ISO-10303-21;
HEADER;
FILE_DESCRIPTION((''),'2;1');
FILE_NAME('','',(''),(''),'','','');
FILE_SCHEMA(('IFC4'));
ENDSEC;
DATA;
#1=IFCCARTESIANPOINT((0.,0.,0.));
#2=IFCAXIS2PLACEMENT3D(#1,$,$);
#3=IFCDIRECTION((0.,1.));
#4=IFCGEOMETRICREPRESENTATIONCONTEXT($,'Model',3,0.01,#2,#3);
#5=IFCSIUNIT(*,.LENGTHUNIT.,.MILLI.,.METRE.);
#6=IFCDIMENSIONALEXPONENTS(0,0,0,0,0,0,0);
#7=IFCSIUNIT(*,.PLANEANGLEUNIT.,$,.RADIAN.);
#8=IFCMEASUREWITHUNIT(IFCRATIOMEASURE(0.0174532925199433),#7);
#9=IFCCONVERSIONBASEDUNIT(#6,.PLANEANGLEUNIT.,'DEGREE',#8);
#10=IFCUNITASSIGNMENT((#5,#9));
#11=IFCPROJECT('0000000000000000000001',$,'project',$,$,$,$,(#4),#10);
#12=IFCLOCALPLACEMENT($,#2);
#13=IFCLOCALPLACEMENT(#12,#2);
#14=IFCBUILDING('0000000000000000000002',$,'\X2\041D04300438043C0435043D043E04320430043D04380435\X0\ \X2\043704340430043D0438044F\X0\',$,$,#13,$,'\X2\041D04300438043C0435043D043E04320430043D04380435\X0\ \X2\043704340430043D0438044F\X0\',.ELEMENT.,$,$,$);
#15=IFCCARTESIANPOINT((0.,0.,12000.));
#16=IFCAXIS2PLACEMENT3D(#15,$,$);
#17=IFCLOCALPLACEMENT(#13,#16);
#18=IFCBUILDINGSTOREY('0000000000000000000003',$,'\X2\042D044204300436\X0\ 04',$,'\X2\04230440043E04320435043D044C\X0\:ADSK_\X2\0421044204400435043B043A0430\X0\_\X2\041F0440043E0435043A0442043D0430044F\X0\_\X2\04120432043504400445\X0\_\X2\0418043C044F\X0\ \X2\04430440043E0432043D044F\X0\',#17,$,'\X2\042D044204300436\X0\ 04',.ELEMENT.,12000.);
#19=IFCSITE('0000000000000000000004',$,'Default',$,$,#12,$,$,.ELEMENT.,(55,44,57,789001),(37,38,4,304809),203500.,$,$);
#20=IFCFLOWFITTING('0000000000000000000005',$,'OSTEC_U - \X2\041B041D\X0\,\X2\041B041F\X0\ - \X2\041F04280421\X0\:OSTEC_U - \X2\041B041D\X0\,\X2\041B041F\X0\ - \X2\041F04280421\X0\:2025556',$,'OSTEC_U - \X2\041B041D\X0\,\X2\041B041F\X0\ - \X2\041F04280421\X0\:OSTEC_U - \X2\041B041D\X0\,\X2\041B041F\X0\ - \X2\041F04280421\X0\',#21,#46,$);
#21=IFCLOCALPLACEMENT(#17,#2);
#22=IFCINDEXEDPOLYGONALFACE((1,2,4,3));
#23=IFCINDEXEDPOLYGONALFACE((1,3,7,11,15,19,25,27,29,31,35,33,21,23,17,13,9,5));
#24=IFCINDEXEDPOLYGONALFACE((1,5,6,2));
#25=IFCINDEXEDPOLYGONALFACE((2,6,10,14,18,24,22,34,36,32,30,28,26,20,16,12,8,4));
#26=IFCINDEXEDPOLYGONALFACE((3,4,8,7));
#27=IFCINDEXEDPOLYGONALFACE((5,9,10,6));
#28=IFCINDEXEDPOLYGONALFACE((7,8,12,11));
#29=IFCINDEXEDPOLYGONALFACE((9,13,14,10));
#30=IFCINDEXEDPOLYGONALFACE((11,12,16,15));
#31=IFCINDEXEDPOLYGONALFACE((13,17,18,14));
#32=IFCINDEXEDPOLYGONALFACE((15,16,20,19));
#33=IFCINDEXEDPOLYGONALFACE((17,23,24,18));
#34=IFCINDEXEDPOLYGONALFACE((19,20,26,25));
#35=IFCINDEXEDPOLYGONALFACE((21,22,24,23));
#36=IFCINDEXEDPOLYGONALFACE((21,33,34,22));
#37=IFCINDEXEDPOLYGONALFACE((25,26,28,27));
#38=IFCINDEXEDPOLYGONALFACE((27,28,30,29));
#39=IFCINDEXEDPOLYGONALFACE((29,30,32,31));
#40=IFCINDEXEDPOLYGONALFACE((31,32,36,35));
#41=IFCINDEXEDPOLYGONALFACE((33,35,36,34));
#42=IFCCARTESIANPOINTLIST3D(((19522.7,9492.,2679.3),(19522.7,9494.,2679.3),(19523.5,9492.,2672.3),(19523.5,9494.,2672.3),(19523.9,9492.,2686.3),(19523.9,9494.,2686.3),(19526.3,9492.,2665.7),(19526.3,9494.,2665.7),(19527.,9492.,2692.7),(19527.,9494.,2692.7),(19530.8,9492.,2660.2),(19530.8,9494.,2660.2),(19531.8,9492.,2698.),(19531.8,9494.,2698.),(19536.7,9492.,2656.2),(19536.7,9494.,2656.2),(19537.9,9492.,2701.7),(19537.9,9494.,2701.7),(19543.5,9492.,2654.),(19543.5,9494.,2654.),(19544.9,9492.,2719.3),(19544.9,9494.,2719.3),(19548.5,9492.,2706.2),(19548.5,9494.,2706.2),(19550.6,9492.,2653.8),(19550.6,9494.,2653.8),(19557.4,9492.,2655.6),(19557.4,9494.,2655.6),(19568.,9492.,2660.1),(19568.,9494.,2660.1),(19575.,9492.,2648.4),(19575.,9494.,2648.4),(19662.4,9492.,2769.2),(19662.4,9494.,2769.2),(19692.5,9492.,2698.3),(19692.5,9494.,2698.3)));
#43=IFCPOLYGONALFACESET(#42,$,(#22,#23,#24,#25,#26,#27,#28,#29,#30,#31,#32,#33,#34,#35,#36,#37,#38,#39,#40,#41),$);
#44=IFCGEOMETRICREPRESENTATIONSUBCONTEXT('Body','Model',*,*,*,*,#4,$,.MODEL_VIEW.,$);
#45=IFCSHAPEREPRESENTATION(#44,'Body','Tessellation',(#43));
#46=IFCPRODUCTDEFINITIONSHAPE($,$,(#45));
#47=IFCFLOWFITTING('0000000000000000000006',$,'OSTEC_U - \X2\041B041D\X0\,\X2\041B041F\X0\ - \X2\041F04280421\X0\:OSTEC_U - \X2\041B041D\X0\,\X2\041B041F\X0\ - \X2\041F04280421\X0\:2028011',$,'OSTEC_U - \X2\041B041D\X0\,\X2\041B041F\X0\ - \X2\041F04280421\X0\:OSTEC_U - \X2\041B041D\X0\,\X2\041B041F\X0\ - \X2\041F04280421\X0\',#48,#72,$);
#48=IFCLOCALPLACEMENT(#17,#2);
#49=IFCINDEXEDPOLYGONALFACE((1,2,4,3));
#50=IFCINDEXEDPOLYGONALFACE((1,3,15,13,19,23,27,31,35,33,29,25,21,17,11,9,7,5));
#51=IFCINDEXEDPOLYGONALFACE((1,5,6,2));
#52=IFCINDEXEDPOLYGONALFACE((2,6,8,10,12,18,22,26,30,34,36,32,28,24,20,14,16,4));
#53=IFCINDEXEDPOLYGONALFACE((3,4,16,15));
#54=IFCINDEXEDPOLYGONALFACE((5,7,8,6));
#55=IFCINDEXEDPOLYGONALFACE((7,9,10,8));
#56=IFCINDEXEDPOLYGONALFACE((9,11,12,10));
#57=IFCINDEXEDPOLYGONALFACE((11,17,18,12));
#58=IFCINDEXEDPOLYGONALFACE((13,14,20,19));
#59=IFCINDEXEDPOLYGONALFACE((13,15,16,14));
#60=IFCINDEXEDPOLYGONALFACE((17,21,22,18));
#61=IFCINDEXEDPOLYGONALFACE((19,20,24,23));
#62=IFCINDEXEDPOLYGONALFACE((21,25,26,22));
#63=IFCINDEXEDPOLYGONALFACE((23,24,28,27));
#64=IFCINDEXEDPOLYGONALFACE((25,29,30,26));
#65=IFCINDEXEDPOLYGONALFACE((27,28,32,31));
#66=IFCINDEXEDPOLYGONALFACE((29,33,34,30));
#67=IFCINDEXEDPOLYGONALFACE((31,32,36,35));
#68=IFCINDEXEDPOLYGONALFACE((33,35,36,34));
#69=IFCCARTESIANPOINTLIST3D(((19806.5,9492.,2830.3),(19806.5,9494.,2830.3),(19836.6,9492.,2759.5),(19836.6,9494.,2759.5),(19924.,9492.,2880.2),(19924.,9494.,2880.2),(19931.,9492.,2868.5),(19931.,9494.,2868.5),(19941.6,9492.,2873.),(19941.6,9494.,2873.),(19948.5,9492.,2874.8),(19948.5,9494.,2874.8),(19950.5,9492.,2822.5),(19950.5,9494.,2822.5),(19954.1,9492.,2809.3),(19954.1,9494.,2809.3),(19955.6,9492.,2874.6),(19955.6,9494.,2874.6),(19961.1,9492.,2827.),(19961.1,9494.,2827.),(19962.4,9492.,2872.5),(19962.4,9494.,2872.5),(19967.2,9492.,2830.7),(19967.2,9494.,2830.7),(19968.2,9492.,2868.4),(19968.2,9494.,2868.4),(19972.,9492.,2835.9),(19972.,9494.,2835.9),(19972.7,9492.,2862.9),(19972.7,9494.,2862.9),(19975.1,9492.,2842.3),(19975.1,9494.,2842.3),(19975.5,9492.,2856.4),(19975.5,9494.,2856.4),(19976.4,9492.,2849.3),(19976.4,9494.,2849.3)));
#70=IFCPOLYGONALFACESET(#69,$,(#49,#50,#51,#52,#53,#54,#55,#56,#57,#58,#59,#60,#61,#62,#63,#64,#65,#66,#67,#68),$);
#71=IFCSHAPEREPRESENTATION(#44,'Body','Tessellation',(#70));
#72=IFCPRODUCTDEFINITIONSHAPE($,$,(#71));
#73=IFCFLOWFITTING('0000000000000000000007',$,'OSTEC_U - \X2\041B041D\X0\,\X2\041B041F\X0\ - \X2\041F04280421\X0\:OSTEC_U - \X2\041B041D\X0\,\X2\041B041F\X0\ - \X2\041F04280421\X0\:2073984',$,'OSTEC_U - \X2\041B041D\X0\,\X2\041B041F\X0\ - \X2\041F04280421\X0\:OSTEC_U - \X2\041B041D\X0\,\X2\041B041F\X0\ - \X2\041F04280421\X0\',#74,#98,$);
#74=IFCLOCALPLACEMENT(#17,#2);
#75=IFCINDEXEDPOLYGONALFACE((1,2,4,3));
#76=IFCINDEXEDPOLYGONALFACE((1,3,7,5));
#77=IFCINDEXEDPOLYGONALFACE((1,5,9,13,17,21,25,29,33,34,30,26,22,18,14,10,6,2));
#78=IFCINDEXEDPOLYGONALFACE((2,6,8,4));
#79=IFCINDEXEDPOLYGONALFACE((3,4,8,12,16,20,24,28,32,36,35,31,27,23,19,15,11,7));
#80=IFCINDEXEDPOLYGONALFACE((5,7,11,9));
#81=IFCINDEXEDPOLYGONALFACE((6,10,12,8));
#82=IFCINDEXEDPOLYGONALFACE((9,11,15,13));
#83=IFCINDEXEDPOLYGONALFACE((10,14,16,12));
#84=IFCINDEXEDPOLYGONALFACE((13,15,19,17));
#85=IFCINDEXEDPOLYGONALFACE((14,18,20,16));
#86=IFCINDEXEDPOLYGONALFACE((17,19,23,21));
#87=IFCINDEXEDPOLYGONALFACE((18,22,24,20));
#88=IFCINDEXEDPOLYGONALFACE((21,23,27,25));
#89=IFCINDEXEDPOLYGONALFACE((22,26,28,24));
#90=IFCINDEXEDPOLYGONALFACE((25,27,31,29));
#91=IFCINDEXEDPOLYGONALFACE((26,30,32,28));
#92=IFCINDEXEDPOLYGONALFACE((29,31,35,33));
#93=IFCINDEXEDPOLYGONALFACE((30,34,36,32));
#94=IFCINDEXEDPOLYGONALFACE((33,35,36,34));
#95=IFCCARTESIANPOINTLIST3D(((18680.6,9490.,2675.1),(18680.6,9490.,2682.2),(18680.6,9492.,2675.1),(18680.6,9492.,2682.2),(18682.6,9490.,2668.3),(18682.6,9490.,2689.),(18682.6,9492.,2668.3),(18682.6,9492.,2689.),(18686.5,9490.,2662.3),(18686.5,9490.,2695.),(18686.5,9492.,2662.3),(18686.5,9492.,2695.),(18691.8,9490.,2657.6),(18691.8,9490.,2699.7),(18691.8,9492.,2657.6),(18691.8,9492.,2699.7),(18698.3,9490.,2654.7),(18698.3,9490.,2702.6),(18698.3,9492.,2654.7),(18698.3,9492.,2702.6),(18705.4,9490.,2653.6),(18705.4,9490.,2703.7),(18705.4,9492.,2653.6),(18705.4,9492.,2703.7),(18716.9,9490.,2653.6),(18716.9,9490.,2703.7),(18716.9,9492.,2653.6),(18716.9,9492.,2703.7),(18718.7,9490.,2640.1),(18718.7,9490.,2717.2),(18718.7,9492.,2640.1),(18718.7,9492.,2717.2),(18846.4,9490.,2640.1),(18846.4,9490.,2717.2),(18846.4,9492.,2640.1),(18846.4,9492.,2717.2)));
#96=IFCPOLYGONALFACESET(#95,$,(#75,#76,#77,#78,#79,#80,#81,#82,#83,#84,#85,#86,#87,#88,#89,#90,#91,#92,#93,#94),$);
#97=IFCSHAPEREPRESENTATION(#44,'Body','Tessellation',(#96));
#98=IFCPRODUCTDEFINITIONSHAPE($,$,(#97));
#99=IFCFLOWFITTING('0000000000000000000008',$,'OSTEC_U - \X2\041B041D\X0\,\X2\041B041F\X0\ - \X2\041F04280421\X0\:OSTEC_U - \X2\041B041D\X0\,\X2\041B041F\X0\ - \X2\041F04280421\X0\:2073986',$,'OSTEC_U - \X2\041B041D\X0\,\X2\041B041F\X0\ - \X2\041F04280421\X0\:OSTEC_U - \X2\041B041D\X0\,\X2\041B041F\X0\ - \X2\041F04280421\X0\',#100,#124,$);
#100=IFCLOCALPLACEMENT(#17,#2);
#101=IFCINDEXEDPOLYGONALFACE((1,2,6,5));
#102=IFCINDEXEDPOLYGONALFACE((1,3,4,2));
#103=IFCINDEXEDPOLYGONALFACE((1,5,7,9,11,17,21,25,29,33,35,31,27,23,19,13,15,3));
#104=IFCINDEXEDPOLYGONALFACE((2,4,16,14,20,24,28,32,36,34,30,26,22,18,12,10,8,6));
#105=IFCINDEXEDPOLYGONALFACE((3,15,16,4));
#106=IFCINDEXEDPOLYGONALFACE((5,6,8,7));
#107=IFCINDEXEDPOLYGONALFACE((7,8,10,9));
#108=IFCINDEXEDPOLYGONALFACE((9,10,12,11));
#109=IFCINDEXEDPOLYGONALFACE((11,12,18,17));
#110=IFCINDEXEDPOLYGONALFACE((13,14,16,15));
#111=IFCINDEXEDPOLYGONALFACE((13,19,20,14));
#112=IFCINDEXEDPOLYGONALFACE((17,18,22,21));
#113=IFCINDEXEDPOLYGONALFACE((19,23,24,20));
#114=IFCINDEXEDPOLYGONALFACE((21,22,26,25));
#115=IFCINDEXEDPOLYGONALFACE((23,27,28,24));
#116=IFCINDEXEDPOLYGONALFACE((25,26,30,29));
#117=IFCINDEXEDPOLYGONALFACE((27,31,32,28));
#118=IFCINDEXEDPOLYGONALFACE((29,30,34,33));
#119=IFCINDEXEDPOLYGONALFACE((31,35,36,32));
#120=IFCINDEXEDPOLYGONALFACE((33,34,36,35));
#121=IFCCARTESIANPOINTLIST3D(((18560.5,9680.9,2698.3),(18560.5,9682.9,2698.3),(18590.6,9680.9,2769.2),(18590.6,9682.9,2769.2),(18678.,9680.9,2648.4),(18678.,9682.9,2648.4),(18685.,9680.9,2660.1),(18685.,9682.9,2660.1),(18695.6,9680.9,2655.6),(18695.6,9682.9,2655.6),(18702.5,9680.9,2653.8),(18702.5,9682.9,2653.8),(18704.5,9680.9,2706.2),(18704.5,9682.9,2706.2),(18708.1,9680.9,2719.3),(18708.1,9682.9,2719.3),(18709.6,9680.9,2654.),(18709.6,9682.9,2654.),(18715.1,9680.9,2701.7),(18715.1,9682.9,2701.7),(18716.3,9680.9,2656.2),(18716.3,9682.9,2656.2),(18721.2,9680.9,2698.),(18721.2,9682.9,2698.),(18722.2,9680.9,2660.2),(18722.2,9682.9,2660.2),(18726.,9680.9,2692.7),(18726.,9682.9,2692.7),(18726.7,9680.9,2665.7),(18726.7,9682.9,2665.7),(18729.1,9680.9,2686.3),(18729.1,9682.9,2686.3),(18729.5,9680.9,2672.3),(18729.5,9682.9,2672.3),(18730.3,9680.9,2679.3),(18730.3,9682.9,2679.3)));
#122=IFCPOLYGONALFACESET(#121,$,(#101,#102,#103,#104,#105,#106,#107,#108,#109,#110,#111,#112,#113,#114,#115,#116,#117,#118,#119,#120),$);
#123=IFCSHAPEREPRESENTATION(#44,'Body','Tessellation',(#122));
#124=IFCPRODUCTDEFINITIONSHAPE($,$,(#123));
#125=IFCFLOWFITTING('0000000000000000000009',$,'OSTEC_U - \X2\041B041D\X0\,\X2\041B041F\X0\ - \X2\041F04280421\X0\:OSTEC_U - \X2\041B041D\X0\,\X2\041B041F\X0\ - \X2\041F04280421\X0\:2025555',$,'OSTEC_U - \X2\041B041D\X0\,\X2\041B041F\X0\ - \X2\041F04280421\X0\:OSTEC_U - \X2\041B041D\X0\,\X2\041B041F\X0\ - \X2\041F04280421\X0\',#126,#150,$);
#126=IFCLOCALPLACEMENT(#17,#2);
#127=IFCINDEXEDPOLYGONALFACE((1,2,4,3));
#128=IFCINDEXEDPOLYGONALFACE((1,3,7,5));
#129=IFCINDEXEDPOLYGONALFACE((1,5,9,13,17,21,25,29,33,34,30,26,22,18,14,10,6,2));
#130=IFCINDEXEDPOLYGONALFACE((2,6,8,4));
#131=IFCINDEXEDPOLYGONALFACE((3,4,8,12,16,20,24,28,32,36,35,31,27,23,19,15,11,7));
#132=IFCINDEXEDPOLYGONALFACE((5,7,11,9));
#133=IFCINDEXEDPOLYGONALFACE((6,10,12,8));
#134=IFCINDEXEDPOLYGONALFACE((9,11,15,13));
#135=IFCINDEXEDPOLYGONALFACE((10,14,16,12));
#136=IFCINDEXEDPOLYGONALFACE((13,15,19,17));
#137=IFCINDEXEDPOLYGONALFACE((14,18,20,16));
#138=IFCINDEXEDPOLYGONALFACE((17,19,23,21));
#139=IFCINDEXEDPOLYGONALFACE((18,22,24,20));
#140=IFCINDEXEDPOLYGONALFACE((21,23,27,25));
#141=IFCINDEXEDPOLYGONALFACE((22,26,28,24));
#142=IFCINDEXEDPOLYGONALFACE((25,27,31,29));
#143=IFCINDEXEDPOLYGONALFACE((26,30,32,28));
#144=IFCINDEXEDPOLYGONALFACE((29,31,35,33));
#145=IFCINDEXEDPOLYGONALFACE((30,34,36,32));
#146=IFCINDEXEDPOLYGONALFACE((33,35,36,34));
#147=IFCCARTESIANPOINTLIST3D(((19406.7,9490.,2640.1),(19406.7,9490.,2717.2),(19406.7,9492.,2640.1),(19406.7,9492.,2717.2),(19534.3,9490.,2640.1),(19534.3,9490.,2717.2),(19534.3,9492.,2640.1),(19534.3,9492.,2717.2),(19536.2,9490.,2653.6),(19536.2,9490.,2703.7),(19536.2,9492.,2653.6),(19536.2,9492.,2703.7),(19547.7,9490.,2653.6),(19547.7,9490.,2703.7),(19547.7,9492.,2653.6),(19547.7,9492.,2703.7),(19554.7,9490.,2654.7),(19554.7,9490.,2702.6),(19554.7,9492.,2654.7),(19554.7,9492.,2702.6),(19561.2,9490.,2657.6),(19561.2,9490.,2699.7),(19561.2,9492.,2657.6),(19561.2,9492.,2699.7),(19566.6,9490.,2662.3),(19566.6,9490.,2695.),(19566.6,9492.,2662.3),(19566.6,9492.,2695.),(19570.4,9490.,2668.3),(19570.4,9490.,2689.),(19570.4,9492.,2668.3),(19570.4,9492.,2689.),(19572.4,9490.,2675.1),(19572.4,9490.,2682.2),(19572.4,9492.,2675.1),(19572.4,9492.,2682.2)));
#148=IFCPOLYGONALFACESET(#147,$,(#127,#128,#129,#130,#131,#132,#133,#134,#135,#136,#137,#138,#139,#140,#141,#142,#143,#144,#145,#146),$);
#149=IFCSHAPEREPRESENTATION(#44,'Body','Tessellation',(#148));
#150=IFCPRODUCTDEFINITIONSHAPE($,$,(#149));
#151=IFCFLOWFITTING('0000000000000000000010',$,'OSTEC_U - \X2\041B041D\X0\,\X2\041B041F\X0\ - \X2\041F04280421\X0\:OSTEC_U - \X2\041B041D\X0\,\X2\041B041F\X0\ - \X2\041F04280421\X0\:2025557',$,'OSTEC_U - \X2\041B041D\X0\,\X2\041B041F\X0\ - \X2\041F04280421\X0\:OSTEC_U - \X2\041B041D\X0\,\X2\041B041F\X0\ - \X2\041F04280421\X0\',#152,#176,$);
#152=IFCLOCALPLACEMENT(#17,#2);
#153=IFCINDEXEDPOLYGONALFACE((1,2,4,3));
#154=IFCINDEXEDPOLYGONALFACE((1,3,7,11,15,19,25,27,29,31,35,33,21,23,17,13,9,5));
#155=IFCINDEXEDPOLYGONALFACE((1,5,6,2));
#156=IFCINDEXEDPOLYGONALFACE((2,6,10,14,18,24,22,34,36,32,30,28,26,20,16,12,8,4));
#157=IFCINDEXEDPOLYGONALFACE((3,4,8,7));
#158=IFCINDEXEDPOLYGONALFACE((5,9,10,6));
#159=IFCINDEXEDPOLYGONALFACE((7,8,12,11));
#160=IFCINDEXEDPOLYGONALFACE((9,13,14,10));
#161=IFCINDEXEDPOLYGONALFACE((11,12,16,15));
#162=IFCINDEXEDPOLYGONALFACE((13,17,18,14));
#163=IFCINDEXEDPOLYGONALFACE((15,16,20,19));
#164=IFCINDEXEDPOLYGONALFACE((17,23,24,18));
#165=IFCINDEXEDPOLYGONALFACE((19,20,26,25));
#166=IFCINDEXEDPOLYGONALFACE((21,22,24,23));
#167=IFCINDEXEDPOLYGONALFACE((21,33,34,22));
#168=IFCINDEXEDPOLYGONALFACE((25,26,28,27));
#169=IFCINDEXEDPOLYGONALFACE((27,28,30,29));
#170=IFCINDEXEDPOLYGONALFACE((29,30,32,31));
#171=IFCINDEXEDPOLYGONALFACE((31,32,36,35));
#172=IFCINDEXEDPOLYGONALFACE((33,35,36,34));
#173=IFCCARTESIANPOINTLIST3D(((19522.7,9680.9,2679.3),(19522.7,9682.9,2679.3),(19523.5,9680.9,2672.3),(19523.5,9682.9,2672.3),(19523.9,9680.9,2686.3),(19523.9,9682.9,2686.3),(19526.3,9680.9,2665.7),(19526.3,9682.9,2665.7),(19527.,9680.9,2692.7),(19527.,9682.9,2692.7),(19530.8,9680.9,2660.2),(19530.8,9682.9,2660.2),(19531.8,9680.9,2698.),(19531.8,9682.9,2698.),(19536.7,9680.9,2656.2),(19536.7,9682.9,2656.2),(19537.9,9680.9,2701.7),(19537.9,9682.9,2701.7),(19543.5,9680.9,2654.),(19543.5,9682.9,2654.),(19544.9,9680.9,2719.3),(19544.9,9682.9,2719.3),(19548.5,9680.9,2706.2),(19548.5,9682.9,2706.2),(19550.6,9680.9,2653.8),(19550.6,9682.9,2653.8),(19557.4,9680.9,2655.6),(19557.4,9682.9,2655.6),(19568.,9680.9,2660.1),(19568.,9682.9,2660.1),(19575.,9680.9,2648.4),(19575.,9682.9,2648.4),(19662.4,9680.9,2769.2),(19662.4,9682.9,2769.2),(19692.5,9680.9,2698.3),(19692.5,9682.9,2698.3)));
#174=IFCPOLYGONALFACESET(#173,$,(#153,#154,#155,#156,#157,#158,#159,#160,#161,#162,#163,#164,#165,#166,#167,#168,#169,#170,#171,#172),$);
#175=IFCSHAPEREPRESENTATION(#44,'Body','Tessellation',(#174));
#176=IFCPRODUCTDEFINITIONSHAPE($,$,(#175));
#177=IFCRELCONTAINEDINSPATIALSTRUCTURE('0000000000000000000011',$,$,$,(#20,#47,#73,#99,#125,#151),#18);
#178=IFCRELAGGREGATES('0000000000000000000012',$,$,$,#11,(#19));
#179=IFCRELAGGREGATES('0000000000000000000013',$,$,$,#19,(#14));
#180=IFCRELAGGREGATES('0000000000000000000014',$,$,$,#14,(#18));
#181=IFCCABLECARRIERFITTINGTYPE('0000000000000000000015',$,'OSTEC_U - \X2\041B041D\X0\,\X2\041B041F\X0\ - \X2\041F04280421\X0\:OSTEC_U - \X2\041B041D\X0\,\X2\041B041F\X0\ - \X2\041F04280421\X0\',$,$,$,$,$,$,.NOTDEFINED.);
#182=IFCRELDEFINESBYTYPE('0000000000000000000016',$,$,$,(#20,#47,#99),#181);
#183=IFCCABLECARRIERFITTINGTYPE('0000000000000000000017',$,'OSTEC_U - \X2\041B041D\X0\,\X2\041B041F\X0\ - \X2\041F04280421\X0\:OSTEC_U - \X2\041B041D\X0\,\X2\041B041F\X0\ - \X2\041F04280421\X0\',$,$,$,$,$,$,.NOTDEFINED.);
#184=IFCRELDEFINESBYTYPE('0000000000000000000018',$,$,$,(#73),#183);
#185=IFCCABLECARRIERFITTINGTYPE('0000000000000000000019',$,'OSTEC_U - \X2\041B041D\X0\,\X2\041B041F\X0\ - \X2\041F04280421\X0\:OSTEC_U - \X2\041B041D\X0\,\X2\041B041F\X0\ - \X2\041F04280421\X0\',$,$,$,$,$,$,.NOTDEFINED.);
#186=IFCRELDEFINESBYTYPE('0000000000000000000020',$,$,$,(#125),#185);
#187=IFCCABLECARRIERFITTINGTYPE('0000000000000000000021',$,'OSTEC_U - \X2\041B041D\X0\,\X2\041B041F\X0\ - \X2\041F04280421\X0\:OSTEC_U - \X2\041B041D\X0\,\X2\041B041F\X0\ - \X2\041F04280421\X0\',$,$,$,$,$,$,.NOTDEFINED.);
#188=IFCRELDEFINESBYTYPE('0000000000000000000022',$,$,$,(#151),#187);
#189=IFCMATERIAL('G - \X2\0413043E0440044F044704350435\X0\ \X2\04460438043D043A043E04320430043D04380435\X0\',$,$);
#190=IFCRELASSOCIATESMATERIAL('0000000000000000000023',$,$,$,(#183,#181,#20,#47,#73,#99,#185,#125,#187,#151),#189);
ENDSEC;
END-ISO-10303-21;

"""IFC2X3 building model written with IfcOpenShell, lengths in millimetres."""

from ifc_helpers import new_model, entity, si_unit, converted_unit, direction, frame, frame_2d, origin, place, context, subcontext, project, spatial, polyline, circle_curve, parameter, trimmed, segment, composite_curve, outline, extrude, source, transform, mapped, material, type_object, type_shapes, element, save


model = new_model("IFC2X3")

# Units and contexts
model_context = context("Model", 3, precision=0.01, world=origin(), true_north=direction((0.0, 1.0)))
body_context = subcontext(model_context, "Body", "Model", "MODEL_VIEW")
ifc_project = project(units=[si_unit("LENGTHUNIT", "METRE", prefix="MILLI"), converted_unit("PLANEANGLEUNIT", "DEGREE", entity("IfcRatioMeasure", 0.0174532925199433), si_unit("PLANEANGLEUNIT", "RADIAN"), dimensions=[0, 0, 0, 0, 0, 0, 0])], contexts=[model_context])

# Site, building, storey
site_placement = place(None, origin())
site = spatial("IfcSite", under=ifc_project, at=site_placement, Name="Default", CompositionType="ELEMENT", RefLatitude=(55, 44, 57, 789001), RefLongitude=(37, 38, 4, 304809), RefElevation=203500.0)
building_placement = place(site_placement, origin())
building = spatial("IfcBuilding", under=site, at=building_placement, Name="Наименование здания", LongName="Наименование здания", CompositionType="ELEMENT")
storey_placement = place(building_placement, frame((0.0, 0.0, 12000.0)))
storey = spatial("IfcBuildingStorey", under=building, at=storey_placement, Name="Этаж 04", ObjectType="Уровень:ADSK_Стрелка_Проектная_Вверх_Имя уровня", LongName="Этаж 04", CompositionType="ELEMENT", Elevation=12000.0)

# Flow fittings
ifc_material = material(Name="G - Горячее цинкование")
cable_carrier_fitting_type_1 = type_object("IfcCableCarrierFittingType", Name="OSTEC_U - ЛН,ЛП - ПШС:OSTEC_U - ЛН,ЛП - ПШС", PredefinedType="NOTDEFINED", material=ifc_material)
shared_shape_1 = source(origin(), body_context, "Body", "SweptSolid", [
    extrude(outline(composite_curve([segment(trimmed(circle_curve(frame_2d((-41.5, 0.0), x_axis=(1.0, 0.0)), 25.0), [parameter(90.0)], [parameter(270.0)], True, "PARAMETER"), True, "CONTINUOUS"), segment(polyline([(-41.5, -25.0), (-30.0, -25.0)]), True, "CONTINUOUS"), segment(polyline([(-30.0, -25.0), (-28.1, -38.5)]), True, "CONTINUOUS"), segment(polyline([(-28.1, -38.5), (99.5, -38.5)]), True, "CONTINUOUS"), segment(polyline([(99.5, -38.5), (99.5, 38.5)]), True, "CONTINUOUS"), segment(polyline([(99.5, 38.5), (-28.1, 38.5)]), True, "CONTINUOUS"), segment(polyline([(-28.1, 38.5), (-30.0, 25.0)]), True, "CONTINUOUS"), segment(polyline([(-30.0, 25.0), (-41.5, 25.0)]), True, "CONTINUOUS")], self_intersect=False)), frame((41.5, 0.0, 0.0), z_axis=(0.0, 0.0, -1.0), x_axis=(1.0, 0.0, 0.0)), (0.0, 0.0, -1.0), 2.0),
])
type_shapes(cable_carrier_fitting_type_1, [shared_shape_1])
cable_carrier_fitting_type_2 = type_object("IfcCableCarrierFittingType", Name="OSTEC_U - ЛН,ЛП - ПШС:OSTEC_U - ЛН,ЛП - ПШС", PredefinedType="NOTDEFINED", material=ifc_material)
type_shapes(cable_carrier_fitting_type_2, [shared_shape_1])
for number, where, z_axis, x_axis, name in (
    (1, (19547.7, 9494.0, 2678.7), (0.0, -1.0, 0.0), (0.920505, 0.0, 0.390731), "OSTEC_U - ЛН,ЛП - ПШС:OSTEC_U - ЛН,ЛП - ПШС:2025556"),
    (2, (19951.4, 9494.0, 2850.0), (0.0, -1.0, 0.0), (-0.920505, 0.0, -0.390731), "OSTEC_U - ЛН,ЛП - ПШС:OSTEC_U - ЛН,ЛП - ПШС:2028011"),
):
    element("IfcFlowFitting", number, at=place(storey_placement, frame(where, z_axis=z_axis, x_axis=x_axis)), inside=storey, type_object=cable_carrier_fitting_type_2, material=ifc_material, Name=name, ObjectType="OSTEC_U - ЛН,ЛП - ПШС:OSTEC_U - ЛН,ЛП - ПШС", context=body_context, shape_type="MappedRepresentation", body=[
        mapped(shared_shape_1, transform((0.0, 0.0, 0.0), scale=1.0)),
    ])
flow_fitting_1_placement = place(storey_placement, frame((18705.3, 9492.0, 2678.7), z_axis=(0.0, -1.0, 0.0), x_axis=(1.0, 0.0, 0.0)))
element("IfcFlowFitting", 3, at=flow_fitting_1_placement, inside=storey, type_object=cable_carrier_fitting_type_1, material=ifc_material, Name="OSTEC_U - ЛН,ЛП - ПШС:OSTEC_U - ЛН,ЛП - ПШС:2073984", ObjectType="OSTEC_U - ЛН,ЛП - ПШС:OSTEC_U - ЛН,ЛП - ПШС", context=body_context, shape_type="MappedRepresentation", body=[
    mapped(shared_shape_1, transform((0.0, 0.0, 0.0), scale=1.0)),
])
flow_fitting_2_placement = place(storey_placement, frame((18705.3, 9680.9, 2678.7), z_axis=(0.0, 1.0, 0.0), x_axis=(-0.920505, 0.0, 0.390731)))
element("IfcFlowFitting", 4, at=flow_fitting_2_placement, inside=storey, type_object=cable_carrier_fitting_type_2, material=ifc_material, Name="OSTEC_U - ЛН,ЛП - ПШС:OSTEC_U - ЛН,ЛП - ПШС:2073986", ObjectType="OSTEC_U - ЛН,ЛП - ПШС:OSTEC_U - ЛН,ЛП - ПШС", context=body_context, shape_type="MappedRepresentation", body=[
    mapped(shared_shape_1, transform((0.0, 0.0, 0.0), scale=1.0)),
])
cable_carrier_fitting_type_3 = type_object("IfcCableCarrierFittingType", Name="OSTEC_U - ЛН,ЛП - ПШС:OSTEC_U - ЛН,ЛП - ПШС", PredefinedType="NOTDEFINED", material=ifc_material)
shared_shape_2 = source(origin(), body_context, "Body", "SweptSolid", [
    extrude(outline(composite_curve([segment(trimmed(circle_curve(frame_2d((-41.5, 0.0), x_axis=(1.0, 0.0)), 25.0), [parameter(90.0)], [parameter(270.0)], True, "PARAMETER"), True, "CONTINUOUS"), segment(polyline([(-41.5, -25.0), (-30.0, -25.0)]), True, "CONTINUOUS"), segment(polyline([(-30.0, -25.0), (-28.1, -38.5)]), True, "CONTINUOUS"), segment(polyline([(-28.1, -38.5), (99.5, -38.5)]), True, "CONTINUOUS"), segment(polyline([(99.5, -38.5), (99.5, 38.5)]), True, "CONTINUOUS"), segment(polyline([(99.5, 38.5), (-28.1, 38.5)]), True, "CONTINUOUS"), segment(polyline([(-28.1, 38.5), (-30.0, 25.0)]), True, "CONTINUOUS"), segment(polyline([(-30.0, 25.0), (-41.5, 25.0)]), True, "CONTINUOUS")], self_intersect=False)), frame((41.5, 0.0, 0.0)), (0.0, 0.0, 1.0), 2.0),
])
type_shapes(cable_carrier_fitting_type_3, [shared_shape_2])
flow_fitting_3_placement = place(storey_placement, frame((19547.7, 9492.0, 2678.7), z_axis=(0.0, -1.0, 0.0), x_axis=(-1.0, 0.0, 0.0)))
element("IfcFlowFitting", 5, at=flow_fitting_3_placement, inside=storey, type_object=cable_carrier_fitting_type_3, material=ifc_material, Name="OSTEC_U - ЛН,ЛП - ПШС:OSTEC_U - ЛН,ЛП - ПШС:2025555", ObjectType="OSTEC_U - ЛН,ЛП - ПШС:OSTEC_U - ЛН,ЛП - ПШС", context=body_context, shape_type="MappedRepresentation", body=[
    mapped(shared_shape_2, transform((0.0, 0.0, 0.0), scale=1.0)),
])
cable_carrier_fitting_type_4 = type_object("IfcCableCarrierFittingType", Name="OSTEC_U - ЛН,ЛП - ПШС:OSTEC_U - ЛН,ЛП - ПШС", PredefinedType="NOTDEFINED", material=ifc_material)
type_shapes(cable_carrier_fitting_type_4, [shared_shape_2])
flow_fitting_4_placement = place(storey_placement, frame((19547.7, 9680.9, 2678.7), z_axis=(0.0, 1.0, 0.0), x_axis=(0.920505, 0.0, 0.390731)))
element("IfcFlowFitting", 6, at=flow_fitting_4_placement, inside=storey, type_object=cable_carrier_fitting_type_4, material=ifc_material, Name="OSTEC_U - ЛН,ЛП - ПШС:OSTEC_U - ЛН,ЛП - ПШС:2025557", ObjectType="OSTEC_U - ЛН,ЛП - ПШС:OSTEC_U - ЛН,ЛП - ПШС", context=body_context, shape_type="MappedRepresentation", body=[
    mapped(shared_shape_2, transform((0.0, 0.0, 0.0), scale=1.0)),
])

save(model, "model.ifc")
